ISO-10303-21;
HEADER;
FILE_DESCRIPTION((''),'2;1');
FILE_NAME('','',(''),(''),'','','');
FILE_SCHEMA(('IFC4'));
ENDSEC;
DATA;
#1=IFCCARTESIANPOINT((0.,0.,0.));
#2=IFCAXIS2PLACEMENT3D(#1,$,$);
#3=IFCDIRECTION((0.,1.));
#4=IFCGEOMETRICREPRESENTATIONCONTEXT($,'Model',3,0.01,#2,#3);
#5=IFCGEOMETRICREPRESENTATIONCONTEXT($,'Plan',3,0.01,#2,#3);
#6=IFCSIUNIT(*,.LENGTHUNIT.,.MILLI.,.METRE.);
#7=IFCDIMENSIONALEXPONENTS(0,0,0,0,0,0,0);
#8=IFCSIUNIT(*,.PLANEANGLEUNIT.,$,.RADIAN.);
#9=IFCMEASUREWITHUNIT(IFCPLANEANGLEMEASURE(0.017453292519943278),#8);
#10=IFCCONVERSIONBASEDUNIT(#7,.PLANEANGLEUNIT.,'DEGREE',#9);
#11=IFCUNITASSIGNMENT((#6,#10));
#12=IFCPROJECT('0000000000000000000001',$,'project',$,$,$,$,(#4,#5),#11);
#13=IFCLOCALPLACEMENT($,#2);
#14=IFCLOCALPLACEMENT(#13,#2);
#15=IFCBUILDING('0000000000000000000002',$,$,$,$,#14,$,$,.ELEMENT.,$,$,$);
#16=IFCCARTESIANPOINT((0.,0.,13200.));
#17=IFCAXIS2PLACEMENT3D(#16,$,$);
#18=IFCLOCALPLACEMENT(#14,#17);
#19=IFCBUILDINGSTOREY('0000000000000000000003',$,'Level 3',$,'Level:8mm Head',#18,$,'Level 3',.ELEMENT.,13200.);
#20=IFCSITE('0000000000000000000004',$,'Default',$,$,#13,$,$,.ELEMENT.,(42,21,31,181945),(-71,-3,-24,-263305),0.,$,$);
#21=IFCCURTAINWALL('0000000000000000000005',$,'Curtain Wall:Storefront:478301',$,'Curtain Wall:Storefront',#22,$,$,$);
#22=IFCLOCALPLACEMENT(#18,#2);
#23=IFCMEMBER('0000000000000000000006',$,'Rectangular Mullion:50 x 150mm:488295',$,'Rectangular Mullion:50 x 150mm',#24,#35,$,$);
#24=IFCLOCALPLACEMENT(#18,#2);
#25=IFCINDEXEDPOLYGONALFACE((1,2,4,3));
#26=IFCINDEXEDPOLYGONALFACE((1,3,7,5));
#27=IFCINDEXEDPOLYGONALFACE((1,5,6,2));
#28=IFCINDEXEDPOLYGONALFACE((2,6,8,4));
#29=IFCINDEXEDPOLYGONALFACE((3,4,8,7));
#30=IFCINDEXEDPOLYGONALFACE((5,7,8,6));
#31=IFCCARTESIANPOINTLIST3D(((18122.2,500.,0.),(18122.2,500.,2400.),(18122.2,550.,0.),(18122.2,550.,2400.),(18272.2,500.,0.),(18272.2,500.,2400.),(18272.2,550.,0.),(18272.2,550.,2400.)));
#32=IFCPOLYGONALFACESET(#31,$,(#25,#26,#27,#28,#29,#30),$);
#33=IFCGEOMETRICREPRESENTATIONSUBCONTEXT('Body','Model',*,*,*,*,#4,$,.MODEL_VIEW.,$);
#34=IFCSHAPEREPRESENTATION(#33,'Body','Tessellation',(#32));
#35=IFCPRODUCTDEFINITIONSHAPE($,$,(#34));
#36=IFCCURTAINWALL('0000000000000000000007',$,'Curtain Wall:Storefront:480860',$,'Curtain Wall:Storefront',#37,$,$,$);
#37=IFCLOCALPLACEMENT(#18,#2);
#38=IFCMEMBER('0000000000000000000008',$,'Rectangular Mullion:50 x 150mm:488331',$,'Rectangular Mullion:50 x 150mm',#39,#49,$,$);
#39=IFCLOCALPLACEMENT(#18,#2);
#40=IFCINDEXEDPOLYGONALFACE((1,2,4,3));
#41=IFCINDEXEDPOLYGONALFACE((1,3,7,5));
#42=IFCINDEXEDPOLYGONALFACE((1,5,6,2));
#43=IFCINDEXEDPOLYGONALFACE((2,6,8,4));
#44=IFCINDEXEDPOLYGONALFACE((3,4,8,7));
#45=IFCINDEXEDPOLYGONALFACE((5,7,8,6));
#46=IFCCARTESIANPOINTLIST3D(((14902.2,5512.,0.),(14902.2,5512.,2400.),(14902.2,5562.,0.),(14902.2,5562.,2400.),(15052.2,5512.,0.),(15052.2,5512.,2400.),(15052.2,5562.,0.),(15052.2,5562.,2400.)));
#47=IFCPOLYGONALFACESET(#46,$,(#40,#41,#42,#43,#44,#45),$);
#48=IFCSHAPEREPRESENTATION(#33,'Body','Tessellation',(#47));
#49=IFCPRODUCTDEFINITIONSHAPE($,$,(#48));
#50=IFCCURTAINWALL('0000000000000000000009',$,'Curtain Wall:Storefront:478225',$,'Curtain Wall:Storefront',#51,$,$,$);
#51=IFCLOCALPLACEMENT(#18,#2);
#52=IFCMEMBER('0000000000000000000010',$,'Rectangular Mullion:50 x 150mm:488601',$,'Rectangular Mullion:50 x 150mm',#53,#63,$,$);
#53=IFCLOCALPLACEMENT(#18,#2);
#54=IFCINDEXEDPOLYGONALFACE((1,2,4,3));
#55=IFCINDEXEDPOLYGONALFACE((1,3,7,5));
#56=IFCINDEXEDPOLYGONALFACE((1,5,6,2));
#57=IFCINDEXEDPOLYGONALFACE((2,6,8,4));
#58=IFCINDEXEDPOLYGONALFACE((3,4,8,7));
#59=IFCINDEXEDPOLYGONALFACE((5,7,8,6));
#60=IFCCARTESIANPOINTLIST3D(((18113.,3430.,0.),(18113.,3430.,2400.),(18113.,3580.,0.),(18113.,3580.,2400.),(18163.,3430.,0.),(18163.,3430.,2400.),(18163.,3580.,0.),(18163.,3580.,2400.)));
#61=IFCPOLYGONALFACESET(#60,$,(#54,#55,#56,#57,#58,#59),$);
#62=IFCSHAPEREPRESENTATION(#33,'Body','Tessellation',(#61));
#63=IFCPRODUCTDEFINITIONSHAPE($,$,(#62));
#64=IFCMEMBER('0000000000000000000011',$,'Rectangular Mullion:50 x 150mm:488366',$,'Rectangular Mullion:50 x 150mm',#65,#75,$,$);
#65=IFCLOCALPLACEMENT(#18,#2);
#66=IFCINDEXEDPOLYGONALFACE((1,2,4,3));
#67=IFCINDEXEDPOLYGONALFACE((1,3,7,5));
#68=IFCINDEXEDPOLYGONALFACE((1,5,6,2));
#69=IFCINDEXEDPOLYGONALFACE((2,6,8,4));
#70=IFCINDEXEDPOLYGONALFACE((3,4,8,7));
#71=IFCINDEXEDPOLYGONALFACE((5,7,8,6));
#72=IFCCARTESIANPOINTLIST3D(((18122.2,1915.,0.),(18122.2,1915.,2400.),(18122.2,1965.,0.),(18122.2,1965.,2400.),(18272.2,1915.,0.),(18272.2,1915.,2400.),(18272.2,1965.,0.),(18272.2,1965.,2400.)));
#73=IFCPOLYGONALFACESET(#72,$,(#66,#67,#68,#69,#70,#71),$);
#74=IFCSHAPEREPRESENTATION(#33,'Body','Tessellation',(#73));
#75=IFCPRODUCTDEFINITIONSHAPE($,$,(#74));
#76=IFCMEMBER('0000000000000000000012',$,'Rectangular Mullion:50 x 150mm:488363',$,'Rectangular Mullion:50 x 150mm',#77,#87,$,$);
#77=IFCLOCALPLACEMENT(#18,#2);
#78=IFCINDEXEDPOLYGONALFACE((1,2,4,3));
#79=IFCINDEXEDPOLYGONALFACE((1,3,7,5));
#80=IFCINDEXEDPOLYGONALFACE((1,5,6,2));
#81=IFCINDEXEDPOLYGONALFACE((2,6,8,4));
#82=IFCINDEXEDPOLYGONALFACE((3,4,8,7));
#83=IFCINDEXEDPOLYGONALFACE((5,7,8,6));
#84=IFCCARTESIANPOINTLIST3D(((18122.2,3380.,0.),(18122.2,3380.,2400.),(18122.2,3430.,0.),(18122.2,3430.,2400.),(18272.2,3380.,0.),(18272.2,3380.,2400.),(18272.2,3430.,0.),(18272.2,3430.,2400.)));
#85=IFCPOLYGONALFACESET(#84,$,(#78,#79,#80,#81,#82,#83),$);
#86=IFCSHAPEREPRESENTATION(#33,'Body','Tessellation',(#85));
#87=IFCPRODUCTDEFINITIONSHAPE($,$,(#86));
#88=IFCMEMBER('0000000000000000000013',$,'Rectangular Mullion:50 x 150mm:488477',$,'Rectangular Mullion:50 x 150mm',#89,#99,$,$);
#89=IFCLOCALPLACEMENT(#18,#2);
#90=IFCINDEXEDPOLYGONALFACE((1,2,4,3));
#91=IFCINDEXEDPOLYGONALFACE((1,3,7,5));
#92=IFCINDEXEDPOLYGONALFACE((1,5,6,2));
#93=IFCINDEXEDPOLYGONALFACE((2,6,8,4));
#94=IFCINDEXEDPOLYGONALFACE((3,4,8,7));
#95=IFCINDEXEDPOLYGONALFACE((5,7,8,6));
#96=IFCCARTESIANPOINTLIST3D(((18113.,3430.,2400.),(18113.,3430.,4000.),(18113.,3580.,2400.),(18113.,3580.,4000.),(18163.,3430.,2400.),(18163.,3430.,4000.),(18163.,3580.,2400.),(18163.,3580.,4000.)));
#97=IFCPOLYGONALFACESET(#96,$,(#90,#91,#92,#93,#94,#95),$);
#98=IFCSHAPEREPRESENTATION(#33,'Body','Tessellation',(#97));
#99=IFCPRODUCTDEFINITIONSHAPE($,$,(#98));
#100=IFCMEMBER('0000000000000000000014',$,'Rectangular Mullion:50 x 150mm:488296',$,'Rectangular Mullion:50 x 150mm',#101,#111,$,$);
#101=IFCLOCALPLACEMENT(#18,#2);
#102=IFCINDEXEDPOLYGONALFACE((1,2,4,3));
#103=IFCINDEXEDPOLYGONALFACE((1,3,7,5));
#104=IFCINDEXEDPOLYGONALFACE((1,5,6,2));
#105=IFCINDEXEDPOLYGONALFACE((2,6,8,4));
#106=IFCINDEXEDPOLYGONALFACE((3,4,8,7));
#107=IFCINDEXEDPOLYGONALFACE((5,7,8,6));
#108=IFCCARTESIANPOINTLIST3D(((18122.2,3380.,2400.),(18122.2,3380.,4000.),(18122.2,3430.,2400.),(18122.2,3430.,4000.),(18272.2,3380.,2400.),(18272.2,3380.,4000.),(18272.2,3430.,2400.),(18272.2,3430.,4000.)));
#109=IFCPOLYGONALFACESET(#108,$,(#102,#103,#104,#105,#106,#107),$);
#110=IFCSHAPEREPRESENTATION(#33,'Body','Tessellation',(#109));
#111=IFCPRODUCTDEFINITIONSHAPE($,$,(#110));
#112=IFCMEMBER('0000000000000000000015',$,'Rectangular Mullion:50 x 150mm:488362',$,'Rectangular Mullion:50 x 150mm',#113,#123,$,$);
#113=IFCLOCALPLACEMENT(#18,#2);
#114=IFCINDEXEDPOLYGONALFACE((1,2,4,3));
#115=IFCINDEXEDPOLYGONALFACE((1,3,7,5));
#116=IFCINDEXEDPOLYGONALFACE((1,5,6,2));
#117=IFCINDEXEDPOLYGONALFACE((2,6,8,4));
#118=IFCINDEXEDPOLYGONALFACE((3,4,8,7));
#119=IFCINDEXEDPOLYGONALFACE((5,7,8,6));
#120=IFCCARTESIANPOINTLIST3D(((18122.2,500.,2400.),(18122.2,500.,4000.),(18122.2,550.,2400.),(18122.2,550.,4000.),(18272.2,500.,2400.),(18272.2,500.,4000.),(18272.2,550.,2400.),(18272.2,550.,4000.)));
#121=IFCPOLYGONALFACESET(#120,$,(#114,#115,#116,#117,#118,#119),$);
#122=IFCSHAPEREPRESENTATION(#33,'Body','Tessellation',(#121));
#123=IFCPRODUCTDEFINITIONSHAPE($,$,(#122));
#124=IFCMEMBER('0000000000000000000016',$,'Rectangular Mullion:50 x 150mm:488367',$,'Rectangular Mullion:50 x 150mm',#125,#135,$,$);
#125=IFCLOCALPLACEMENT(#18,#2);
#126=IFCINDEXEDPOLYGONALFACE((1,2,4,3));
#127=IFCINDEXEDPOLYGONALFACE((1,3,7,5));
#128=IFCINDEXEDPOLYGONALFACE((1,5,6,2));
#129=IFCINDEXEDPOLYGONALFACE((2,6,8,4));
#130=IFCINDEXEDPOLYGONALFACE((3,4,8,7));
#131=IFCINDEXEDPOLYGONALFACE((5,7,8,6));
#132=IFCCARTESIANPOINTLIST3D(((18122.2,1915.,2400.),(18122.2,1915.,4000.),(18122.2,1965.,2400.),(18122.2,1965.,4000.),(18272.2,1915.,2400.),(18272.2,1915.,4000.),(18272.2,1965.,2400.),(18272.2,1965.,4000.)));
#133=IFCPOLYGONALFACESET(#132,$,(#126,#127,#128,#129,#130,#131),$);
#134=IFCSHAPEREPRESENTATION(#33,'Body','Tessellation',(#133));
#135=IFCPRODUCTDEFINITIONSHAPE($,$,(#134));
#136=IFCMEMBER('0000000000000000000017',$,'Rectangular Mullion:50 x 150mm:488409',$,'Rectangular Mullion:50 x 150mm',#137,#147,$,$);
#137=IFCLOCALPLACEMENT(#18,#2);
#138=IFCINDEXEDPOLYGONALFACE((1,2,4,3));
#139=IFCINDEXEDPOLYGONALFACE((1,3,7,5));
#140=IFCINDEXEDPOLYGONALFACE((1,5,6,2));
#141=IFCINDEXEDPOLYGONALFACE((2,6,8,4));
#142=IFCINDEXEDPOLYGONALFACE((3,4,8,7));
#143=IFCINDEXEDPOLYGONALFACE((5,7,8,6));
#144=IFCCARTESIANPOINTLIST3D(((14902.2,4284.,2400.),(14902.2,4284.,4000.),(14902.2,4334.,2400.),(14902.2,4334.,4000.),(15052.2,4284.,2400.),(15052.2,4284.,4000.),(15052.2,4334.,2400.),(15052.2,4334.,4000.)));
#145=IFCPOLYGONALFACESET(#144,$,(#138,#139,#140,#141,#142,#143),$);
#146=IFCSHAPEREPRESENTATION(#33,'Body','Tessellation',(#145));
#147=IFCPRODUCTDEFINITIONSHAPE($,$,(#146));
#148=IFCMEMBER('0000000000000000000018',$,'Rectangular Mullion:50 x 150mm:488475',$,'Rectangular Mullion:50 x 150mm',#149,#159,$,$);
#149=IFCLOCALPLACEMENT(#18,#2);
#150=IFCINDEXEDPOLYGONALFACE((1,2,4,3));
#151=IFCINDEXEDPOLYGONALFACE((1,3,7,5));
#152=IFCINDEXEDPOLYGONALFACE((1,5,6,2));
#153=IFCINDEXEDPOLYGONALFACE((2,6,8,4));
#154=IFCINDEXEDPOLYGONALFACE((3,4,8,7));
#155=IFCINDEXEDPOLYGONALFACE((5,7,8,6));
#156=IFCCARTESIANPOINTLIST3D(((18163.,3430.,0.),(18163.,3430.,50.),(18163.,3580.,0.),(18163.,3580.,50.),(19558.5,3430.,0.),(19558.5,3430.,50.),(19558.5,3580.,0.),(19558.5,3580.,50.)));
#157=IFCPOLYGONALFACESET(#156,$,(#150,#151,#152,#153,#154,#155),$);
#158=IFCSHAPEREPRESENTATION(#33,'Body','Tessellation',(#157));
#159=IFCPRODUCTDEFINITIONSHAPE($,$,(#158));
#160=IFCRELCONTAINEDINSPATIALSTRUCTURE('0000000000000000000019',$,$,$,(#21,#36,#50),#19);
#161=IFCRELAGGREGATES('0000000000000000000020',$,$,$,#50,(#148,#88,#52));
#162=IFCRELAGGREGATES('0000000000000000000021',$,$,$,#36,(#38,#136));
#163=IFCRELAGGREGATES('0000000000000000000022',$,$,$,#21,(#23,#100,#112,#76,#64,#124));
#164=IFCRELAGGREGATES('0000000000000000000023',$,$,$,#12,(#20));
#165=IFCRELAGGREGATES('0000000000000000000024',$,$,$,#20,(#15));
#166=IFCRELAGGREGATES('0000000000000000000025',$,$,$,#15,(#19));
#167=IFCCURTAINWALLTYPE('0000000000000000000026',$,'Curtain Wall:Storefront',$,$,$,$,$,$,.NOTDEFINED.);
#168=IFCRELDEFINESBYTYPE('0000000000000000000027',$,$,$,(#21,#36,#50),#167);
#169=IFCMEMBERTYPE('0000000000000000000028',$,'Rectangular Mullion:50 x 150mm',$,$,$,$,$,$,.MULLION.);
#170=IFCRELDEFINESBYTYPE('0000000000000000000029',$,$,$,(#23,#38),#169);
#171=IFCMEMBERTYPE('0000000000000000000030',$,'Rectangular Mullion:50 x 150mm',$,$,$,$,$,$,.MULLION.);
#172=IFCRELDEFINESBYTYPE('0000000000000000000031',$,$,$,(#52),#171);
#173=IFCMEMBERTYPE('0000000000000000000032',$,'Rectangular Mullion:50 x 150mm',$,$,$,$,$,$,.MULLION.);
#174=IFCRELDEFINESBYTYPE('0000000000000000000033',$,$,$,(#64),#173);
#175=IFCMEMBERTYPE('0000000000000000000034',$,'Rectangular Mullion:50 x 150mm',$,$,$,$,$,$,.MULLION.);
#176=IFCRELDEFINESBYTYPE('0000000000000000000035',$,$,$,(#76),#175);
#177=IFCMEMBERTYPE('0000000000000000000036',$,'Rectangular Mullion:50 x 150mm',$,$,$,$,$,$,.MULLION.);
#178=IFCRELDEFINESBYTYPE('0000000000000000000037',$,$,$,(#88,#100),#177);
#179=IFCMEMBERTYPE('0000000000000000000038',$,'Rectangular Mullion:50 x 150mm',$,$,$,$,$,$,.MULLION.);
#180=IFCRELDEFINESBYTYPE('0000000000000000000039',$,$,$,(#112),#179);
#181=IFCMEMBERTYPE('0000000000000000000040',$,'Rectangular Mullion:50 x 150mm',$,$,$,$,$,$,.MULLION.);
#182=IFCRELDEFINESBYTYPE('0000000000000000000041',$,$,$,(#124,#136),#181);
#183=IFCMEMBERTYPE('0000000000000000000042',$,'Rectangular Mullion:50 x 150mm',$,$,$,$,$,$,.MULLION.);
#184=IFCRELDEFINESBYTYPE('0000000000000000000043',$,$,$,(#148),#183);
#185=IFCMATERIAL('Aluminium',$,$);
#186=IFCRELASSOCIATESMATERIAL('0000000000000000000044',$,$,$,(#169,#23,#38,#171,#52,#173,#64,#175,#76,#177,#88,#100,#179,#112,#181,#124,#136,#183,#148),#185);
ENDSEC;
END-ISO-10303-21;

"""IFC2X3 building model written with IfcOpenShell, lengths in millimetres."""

from ifc_helpers import new_model, entity, si_unit, converted_unit, direction, frame, origin, origin_2d_with_axis, place, context, subcontext, project, spatial, rectangle, extrude, source, transform, mapped, material, type_object, type_shapes, element, aggregate, save


model = new_model("IFC2X3")

# Units and contexts
model_context = context("Model", 3, precision=0.01, world=origin(), true_north=direction((0.0, 1.0)))
plan_context = context("Plan", 3, precision=0.01, world=origin(), true_north=direction((0.0, 1.0)))
body_context = subcontext(model_context, "Body", "Model", "MODEL_VIEW")
ifc_project = project(units=[si_unit("LENGTHUNIT", "METRE", prefix="MILLI"), converted_unit("PLANEANGLEUNIT", "DEGREE", entity("IfcPlaneAngleMeasure", 0.017453292519943278), si_unit("PLANEANGLEUNIT", "RADIAN"), dimensions=[0, 0, 0, 0, 0, 0, 0])], contexts=[model_context, plan_context])

# Site, building, storey
site_placement = place(None, origin())
site = spatial("IfcSite", under=ifc_project, at=site_placement, Name="Default", CompositionType="ELEMENT", RefLatitude=(42, 21, 31, 181945), RefLongitude=(-71, -3, -24, -263305), RefElevation=0.0)
building_placement = place(site_placement, origin())
building = spatial("IfcBuilding", under=site, at=building_placement, CompositionType="ELEMENT")
storey_placement = place(building_placement, frame((0.0, 0.0, 13200.0)))
storey = spatial("IfcBuildingStorey", under=building, at=storey_placement, Name="Level 3", ObjectType="Level:8mm Head", LongName="Level 3", CompositionType="ELEMENT", Elevation=13200.0)

# Curtain walls, members
curtain_wall_type = type_object("IfcCurtainWallType", Name="Curtain Wall:Storefront", PredefinedType="NOTDEFINED")
curtain_wall_1_placement = place(storey_placement, frame((0.0, 0.0, -13200.0)))
curtain_wall_1 = element("IfcCurtainWall", 1, at=curtain_wall_1_placement, inside=storey, type_object=curtain_wall_type, Name="Curtain Wall:Storefront:478301", ObjectType="Curtain Wall:Storefront")
ifc_material_1 = material(Name="Aluminium")
member_type_1 = type_object("IfcMemberType", Name="Rectangular Mullion:50 x 150mm", PredefinedType="MULLION", material=ifc_material_1)
shared_shape_1 = source(origin(), body_context, "Body", "SweptSolid", [
    extrude(rectangle(XDim=50.0, YDim=150.0, at=origin_2d_with_axis()), frame((-25.0, 0.0, -2400.0), z_axis=(0.0, 0.0, 1.0), x_axis=(-1.0, 0.0, 0.0)), (0.0, 0.0, 1.0), 2400.0),
])
type_shapes(member_type_1, [shared_shape_1])
member_1_placement = place(curtain_wall_1_placement, frame((18197.2, 500.0, 13200.0), z_axis=(0.0, 0.0, -1.0), x_axis=(0.0, -1.0, 0.0)))
member_1 = element("IfcMember", 2, at=member_1_placement, type_object=member_type_1, material=ifc_material_1, Name="Rectangular Mullion:50 x 150mm:488295", ObjectType="Rectangular Mullion:50 x 150mm", context=body_context, shape_type="MappedRepresentation", body=[
    mapped(shared_shape_1, transform((0.0, 0.0, 0.0), scale=1.0)),
])
curtain_wall_2_placement = place(storey_placement, frame((0.0, 0.0, -13200.0)))
curtain_wall_2 = element("IfcCurtainWall", 3, at=curtain_wall_2_placement, inside=storey, type_object=curtain_wall_type, Name="Curtain Wall:Storefront:480860", ObjectType="Curtain Wall:Storefront")
member_2_placement = place(curtain_wall_2_placement, frame((14977.2, 5562.0, 13200.0), z_axis=(0.0, 0.0, -1.0), x_axis=(0.0, 1.0, 0.0)))
member_2 = element("IfcMember", 4, at=member_2_placement, type_object=member_type_1, material=ifc_material_1, Name="Rectangular Mullion:50 x 150mm:488331", ObjectType="Rectangular Mullion:50 x 150mm", context=body_context, shape_type="MappedRepresentation", body=[
    mapped(shared_shape_1, transform((0.0, 0.0, 0.0), scale=1.0)),
])
curtain_wall_3_placement = place(storey_placement, frame((0.0, 0.0, -13200.0)))
curtain_wall_3 = element("IfcCurtainWall", 5, at=curtain_wall_3_placement, inside=storey, type_object=curtain_wall_type, Name="Curtain Wall:Storefront:478225", ObjectType="Curtain Wall:Storefront")
member_type_2 = type_object("IfcMemberType", Name="Rectangular Mullion:50 x 150mm", PredefinedType="MULLION", material=ifc_material_1)
shared_shape_2 = source(origin(), body_context, "Body", "SweptSolid", [
    extrude(rectangle(XDim=50.0, YDim=150.0, at=origin_2d_with_axis()), frame((-25.0, 0.0, -2400.0), z_axis=(0.0, 0.0, 1.0), x_axis=(-1.0, 0.0, 0.0)), (0.0, 0.0, 1.0), 2400.0),
])
type_shapes(member_type_2, [shared_shape_2])
member_3_placement = place(curtain_wall_3_placement, frame((18113.0, 3505.0, 15600.0), z_axis=(0.0, 0.0, 1.0), x_axis=(-1.0, 0.0, 0.0)))
member_3 = element("IfcMember", 6, at=member_3_placement, type_object=member_type_2, material=ifc_material_1, Name="Rectangular Mullion:50 x 150mm:488601", ObjectType="Rectangular Mullion:50 x 150mm", context=body_context, shape_type="MappedRepresentation", body=[
    mapped(shared_shape_2, transform((0.0, 0.0, 0.0), scale=1.0)),
])

# Members
member_type_3 = type_object("IfcMemberType", Name="Rectangular Mullion:50 x 150mm", PredefinedType="MULLION", material=ifc_material_1)
shared_shape_3 = source(origin(), body_context, "Body", "SweptSolid", [
    extrude(rectangle(XDim=50.0, YDim=150.0, at=origin_2d_with_axis()), frame((0.0, 0.0, -2400.0), z_axis=(0.0, 0.0, 1.0), x_axis=(-1.0, 0.0, 0.0)), (0.0, 0.0, 1.0), 2400.0),
])
type_shapes(member_type_3, [shared_shape_3])
member_4_placement = place(curtain_wall_1_placement, frame((18197.2, 1940.0, 13200.0), z_axis=(0.0, 0.0, -1.0), x_axis=(0.0, -1.0, 0.0)))
member_4 = element("IfcMember", 7, at=member_4_placement, type_object=member_type_3, material=ifc_material_1, Name="Rectangular Mullion:50 x 150mm:488366", ObjectType="Rectangular Mullion:50 x 150mm", context=body_context, shape_type="MappedRepresentation", body=[
    mapped(shared_shape_3, transform((0.0, 0.0, 0.0), scale=1.0)),
])
member_type_4 = type_object("IfcMemberType", Name="Rectangular Mullion:50 x 150mm", PredefinedType="MULLION", material=ifc_material_1)
shared_shape_4 = source(origin(), body_context, "Body", "SweptSolid", [
    extrude(rectangle(XDim=50.0, YDim=150.0, at=origin_2d_with_axis()), frame((-25.0, 0.0, -2400.0), z_axis=(0.0, 0.0, 1.0), x_axis=(-1.0, 0.0, 0.0)), (0.0, 0.0, 1.0), 2400.0),
])
type_shapes(member_type_4, [shared_shape_4])
member_5_placement = place(curtain_wall_1_placement, frame((18197.2, 3430.0, 15600.0), z_axis=(0.0, 0.0, 1.0), x_axis=(0.0, 1.0, 0.0)))
member_5 = element("IfcMember", 8, at=member_5_placement, type_object=member_type_4, material=ifc_material_1, Name="Rectangular Mullion:50 x 150mm:488363", ObjectType="Rectangular Mullion:50 x 150mm", context=body_context, shape_type="MappedRepresentation", body=[
    mapped(shared_shape_4, transform((0.0, 0.0, 0.0), scale=1.0)),
])
member_type_5 = type_object("IfcMemberType", Name="Rectangular Mullion:50 x 150mm", PredefinedType="MULLION", material=ifc_material_1)
shared_shape_5 = source(origin(), body_context, "Body", "SweptSolid", [
    extrude(rectangle(XDim=50.0, YDim=150.0, at=origin_2d_with_axis()), frame((-25.0, 0.0, -1600.0), z_axis=(0.0, 0.0, 1.0), x_axis=(-1.0, 0.0, 0.0)), (0.0, 0.0, 1.0), 1600.0),
])
type_shapes(member_type_5, [shared_shape_5])
member_6_placement = place(curtain_wall_3_placement, frame((18113.0, 3505.0, 17200.0), z_axis=(0.0, 0.0, 1.0), x_axis=(-1.0, 0.0, 0.0)))
member_6 = element("IfcMember", 9, at=member_6_placement, type_object=member_type_5, material=ifc_material_1, Name="Rectangular Mullion:50 x 150mm:488477", ObjectType="Rectangular Mullion:50 x 150mm", context=body_context, shape_type="MappedRepresentation", body=[
    mapped(shared_shape_5, transform((0.0, 0.0, 0.0), scale=1.0)),
])
member_7_placement = place(curtain_wall_1_placement, frame((18197.2, 3430.0, 17200.0), z_axis=(0.0, 0.0, 1.0), x_axis=(0.0, 1.0, 0.0)))
member_7 = element("IfcMember", 10, at=member_7_placement, type_object=member_type_5, material=ifc_material_1, Name="Rectangular Mullion:50 x 150mm:488296", ObjectType="Rectangular Mullion:50 x 150mm", context=body_context, shape_type="MappedRepresentation", body=[
    mapped(shared_shape_5, transform((0.0, 0.0, 0.0), scale=1.0)),
])
member_type_6 = type_object("IfcMemberType", Name="Rectangular Mullion:50 x 150mm", PredefinedType="MULLION", material=ifc_material_1)
shared_shape_6 = source(origin(), body_context, "Body", "SweptSolid", [
    extrude(rectangle(XDim=50.0, YDim=150.0, at=origin_2d_with_axis()), frame((-25.0, 0.0, -1600.0), z_axis=(0.0, 0.0, 1.0), x_axis=(-1.0, 0.0, 0.0)), (0.0, 0.0, 1.0), 1600.0),
])
type_shapes(member_type_6, [shared_shape_6])
member_8_placement = place(curtain_wall_1_placement, frame((18197.2, 500.0, 15600.0), z_axis=(0.0, 0.0, -1.0), x_axis=(0.0, -1.0, 0.0)))
member_8 = element("IfcMember", 11, at=member_8_placement, type_object=member_type_6, material=ifc_material_1, Name="Rectangular Mullion:50 x 150mm:488362", ObjectType="Rectangular Mullion:50 x 150mm", context=body_context, shape_type="MappedRepresentation", body=[
    mapped(shared_shape_6, transform((0.0, 0.0, 0.0), scale=1.0)),
])
member_type_7 = type_object("IfcMemberType", Name="Rectangular Mullion:50 x 150mm", PredefinedType="MULLION", material=ifc_material_1)
shared_shape_7 = source(origin(), body_context, "Body", "SweptSolid", [
    extrude(rectangle(XDim=50.0, YDim=150.0, at=origin_2d_with_axis()), frame((0.0, 0.0, -1600.0), z_axis=(0.0, 0.0, 1.0), x_axis=(-1.0, 0.0, 0.0)), (0.0, 0.0, 1.0), 1600.0),
])
type_shapes(member_type_7, [shared_shape_7])
member_9_placement = place(curtain_wall_1_placement, frame((18197.2, 1940.0, 15600.0), z_axis=(0.0, 0.0, -1.0), x_axis=(0.0, -1.0, 0.0)))
member_9 = element("IfcMember", 12, at=member_9_placement, type_object=member_type_7, material=ifc_material_1, Name="Rectangular Mullion:50 x 150mm:488367", ObjectType="Rectangular Mullion:50 x 150mm", context=body_context, shape_type="MappedRepresentation", body=[
    mapped(shared_shape_7, transform((0.0, 0.0, 0.0), scale=1.0)),
])
member_10_placement = place(curtain_wall_2_placement, frame((14977.2, 4309.0, 15600.0), z_axis=(0.0, 0.0, -1.0), x_axis=(0.0, 1.0, 0.0)))
member_10 = element("IfcMember", 13, at=member_10_placement, type_object=member_type_7, material=ifc_material_1, Name="Rectangular Mullion:50 x 150mm:488409", ObjectType="Rectangular Mullion:50 x 150mm", context=body_context, shape_type="MappedRepresentation", body=[
    mapped(shared_shape_7, transform((0.0, 0.0, 0.0), scale=1.0)),
])
member_type_8 = type_object("IfcMemberType", Name="Rectangular Mullion:50 x 150mm", PredefinedType="MULLION", material=ifc_material_1)
shared_shape_8 = source(origin(), body_context, "Body", "SweptSolid", [
    extrude(rectangle(XDim=50.0, YDim=150.0, at=origin_2d_with_axis()), frame((-25.0, 0.0, -1395.5), z_axis=(0.0, 0.0, 1.0), x_axis=(-1.0, 0.0, 0.0)), (0.0, 0.0, 1.0), 1395.5),
])
type_shapes(member_type_8, [shared_shape_8])
member_11_placement = place(curtain_wall_3_placement, frame((18163.0, 3505.0, 13200.0), z_axis=(-1.0, 0.0, 0.0), x_axis=(0.0, 0.0, -1.0)))
member_11 = element("IfcMember", 14, at=member_11_placement, type_object=member_type_8, material=ifc_material_1, Name="Rectangular Mullion:50 x 150mm:488475", ObjectType="Rectangular Mullion:50 x 150mm", context=body_context, shape_type="MappedRepresentation", body=[
    mapped(shared_shape_8, transform((0.0, 0.0, 0.0), scale=1.0)),
])
aggregate(curtain_wall_3, [member_11, member_6, member_3])

aggregate(curtain_wall_2, [member_2, member_10])

aggregate(curtain_wall_1, [member_1, member_7, member_8, member_5, member_4, member_9])

save(model, "model.ifc")
